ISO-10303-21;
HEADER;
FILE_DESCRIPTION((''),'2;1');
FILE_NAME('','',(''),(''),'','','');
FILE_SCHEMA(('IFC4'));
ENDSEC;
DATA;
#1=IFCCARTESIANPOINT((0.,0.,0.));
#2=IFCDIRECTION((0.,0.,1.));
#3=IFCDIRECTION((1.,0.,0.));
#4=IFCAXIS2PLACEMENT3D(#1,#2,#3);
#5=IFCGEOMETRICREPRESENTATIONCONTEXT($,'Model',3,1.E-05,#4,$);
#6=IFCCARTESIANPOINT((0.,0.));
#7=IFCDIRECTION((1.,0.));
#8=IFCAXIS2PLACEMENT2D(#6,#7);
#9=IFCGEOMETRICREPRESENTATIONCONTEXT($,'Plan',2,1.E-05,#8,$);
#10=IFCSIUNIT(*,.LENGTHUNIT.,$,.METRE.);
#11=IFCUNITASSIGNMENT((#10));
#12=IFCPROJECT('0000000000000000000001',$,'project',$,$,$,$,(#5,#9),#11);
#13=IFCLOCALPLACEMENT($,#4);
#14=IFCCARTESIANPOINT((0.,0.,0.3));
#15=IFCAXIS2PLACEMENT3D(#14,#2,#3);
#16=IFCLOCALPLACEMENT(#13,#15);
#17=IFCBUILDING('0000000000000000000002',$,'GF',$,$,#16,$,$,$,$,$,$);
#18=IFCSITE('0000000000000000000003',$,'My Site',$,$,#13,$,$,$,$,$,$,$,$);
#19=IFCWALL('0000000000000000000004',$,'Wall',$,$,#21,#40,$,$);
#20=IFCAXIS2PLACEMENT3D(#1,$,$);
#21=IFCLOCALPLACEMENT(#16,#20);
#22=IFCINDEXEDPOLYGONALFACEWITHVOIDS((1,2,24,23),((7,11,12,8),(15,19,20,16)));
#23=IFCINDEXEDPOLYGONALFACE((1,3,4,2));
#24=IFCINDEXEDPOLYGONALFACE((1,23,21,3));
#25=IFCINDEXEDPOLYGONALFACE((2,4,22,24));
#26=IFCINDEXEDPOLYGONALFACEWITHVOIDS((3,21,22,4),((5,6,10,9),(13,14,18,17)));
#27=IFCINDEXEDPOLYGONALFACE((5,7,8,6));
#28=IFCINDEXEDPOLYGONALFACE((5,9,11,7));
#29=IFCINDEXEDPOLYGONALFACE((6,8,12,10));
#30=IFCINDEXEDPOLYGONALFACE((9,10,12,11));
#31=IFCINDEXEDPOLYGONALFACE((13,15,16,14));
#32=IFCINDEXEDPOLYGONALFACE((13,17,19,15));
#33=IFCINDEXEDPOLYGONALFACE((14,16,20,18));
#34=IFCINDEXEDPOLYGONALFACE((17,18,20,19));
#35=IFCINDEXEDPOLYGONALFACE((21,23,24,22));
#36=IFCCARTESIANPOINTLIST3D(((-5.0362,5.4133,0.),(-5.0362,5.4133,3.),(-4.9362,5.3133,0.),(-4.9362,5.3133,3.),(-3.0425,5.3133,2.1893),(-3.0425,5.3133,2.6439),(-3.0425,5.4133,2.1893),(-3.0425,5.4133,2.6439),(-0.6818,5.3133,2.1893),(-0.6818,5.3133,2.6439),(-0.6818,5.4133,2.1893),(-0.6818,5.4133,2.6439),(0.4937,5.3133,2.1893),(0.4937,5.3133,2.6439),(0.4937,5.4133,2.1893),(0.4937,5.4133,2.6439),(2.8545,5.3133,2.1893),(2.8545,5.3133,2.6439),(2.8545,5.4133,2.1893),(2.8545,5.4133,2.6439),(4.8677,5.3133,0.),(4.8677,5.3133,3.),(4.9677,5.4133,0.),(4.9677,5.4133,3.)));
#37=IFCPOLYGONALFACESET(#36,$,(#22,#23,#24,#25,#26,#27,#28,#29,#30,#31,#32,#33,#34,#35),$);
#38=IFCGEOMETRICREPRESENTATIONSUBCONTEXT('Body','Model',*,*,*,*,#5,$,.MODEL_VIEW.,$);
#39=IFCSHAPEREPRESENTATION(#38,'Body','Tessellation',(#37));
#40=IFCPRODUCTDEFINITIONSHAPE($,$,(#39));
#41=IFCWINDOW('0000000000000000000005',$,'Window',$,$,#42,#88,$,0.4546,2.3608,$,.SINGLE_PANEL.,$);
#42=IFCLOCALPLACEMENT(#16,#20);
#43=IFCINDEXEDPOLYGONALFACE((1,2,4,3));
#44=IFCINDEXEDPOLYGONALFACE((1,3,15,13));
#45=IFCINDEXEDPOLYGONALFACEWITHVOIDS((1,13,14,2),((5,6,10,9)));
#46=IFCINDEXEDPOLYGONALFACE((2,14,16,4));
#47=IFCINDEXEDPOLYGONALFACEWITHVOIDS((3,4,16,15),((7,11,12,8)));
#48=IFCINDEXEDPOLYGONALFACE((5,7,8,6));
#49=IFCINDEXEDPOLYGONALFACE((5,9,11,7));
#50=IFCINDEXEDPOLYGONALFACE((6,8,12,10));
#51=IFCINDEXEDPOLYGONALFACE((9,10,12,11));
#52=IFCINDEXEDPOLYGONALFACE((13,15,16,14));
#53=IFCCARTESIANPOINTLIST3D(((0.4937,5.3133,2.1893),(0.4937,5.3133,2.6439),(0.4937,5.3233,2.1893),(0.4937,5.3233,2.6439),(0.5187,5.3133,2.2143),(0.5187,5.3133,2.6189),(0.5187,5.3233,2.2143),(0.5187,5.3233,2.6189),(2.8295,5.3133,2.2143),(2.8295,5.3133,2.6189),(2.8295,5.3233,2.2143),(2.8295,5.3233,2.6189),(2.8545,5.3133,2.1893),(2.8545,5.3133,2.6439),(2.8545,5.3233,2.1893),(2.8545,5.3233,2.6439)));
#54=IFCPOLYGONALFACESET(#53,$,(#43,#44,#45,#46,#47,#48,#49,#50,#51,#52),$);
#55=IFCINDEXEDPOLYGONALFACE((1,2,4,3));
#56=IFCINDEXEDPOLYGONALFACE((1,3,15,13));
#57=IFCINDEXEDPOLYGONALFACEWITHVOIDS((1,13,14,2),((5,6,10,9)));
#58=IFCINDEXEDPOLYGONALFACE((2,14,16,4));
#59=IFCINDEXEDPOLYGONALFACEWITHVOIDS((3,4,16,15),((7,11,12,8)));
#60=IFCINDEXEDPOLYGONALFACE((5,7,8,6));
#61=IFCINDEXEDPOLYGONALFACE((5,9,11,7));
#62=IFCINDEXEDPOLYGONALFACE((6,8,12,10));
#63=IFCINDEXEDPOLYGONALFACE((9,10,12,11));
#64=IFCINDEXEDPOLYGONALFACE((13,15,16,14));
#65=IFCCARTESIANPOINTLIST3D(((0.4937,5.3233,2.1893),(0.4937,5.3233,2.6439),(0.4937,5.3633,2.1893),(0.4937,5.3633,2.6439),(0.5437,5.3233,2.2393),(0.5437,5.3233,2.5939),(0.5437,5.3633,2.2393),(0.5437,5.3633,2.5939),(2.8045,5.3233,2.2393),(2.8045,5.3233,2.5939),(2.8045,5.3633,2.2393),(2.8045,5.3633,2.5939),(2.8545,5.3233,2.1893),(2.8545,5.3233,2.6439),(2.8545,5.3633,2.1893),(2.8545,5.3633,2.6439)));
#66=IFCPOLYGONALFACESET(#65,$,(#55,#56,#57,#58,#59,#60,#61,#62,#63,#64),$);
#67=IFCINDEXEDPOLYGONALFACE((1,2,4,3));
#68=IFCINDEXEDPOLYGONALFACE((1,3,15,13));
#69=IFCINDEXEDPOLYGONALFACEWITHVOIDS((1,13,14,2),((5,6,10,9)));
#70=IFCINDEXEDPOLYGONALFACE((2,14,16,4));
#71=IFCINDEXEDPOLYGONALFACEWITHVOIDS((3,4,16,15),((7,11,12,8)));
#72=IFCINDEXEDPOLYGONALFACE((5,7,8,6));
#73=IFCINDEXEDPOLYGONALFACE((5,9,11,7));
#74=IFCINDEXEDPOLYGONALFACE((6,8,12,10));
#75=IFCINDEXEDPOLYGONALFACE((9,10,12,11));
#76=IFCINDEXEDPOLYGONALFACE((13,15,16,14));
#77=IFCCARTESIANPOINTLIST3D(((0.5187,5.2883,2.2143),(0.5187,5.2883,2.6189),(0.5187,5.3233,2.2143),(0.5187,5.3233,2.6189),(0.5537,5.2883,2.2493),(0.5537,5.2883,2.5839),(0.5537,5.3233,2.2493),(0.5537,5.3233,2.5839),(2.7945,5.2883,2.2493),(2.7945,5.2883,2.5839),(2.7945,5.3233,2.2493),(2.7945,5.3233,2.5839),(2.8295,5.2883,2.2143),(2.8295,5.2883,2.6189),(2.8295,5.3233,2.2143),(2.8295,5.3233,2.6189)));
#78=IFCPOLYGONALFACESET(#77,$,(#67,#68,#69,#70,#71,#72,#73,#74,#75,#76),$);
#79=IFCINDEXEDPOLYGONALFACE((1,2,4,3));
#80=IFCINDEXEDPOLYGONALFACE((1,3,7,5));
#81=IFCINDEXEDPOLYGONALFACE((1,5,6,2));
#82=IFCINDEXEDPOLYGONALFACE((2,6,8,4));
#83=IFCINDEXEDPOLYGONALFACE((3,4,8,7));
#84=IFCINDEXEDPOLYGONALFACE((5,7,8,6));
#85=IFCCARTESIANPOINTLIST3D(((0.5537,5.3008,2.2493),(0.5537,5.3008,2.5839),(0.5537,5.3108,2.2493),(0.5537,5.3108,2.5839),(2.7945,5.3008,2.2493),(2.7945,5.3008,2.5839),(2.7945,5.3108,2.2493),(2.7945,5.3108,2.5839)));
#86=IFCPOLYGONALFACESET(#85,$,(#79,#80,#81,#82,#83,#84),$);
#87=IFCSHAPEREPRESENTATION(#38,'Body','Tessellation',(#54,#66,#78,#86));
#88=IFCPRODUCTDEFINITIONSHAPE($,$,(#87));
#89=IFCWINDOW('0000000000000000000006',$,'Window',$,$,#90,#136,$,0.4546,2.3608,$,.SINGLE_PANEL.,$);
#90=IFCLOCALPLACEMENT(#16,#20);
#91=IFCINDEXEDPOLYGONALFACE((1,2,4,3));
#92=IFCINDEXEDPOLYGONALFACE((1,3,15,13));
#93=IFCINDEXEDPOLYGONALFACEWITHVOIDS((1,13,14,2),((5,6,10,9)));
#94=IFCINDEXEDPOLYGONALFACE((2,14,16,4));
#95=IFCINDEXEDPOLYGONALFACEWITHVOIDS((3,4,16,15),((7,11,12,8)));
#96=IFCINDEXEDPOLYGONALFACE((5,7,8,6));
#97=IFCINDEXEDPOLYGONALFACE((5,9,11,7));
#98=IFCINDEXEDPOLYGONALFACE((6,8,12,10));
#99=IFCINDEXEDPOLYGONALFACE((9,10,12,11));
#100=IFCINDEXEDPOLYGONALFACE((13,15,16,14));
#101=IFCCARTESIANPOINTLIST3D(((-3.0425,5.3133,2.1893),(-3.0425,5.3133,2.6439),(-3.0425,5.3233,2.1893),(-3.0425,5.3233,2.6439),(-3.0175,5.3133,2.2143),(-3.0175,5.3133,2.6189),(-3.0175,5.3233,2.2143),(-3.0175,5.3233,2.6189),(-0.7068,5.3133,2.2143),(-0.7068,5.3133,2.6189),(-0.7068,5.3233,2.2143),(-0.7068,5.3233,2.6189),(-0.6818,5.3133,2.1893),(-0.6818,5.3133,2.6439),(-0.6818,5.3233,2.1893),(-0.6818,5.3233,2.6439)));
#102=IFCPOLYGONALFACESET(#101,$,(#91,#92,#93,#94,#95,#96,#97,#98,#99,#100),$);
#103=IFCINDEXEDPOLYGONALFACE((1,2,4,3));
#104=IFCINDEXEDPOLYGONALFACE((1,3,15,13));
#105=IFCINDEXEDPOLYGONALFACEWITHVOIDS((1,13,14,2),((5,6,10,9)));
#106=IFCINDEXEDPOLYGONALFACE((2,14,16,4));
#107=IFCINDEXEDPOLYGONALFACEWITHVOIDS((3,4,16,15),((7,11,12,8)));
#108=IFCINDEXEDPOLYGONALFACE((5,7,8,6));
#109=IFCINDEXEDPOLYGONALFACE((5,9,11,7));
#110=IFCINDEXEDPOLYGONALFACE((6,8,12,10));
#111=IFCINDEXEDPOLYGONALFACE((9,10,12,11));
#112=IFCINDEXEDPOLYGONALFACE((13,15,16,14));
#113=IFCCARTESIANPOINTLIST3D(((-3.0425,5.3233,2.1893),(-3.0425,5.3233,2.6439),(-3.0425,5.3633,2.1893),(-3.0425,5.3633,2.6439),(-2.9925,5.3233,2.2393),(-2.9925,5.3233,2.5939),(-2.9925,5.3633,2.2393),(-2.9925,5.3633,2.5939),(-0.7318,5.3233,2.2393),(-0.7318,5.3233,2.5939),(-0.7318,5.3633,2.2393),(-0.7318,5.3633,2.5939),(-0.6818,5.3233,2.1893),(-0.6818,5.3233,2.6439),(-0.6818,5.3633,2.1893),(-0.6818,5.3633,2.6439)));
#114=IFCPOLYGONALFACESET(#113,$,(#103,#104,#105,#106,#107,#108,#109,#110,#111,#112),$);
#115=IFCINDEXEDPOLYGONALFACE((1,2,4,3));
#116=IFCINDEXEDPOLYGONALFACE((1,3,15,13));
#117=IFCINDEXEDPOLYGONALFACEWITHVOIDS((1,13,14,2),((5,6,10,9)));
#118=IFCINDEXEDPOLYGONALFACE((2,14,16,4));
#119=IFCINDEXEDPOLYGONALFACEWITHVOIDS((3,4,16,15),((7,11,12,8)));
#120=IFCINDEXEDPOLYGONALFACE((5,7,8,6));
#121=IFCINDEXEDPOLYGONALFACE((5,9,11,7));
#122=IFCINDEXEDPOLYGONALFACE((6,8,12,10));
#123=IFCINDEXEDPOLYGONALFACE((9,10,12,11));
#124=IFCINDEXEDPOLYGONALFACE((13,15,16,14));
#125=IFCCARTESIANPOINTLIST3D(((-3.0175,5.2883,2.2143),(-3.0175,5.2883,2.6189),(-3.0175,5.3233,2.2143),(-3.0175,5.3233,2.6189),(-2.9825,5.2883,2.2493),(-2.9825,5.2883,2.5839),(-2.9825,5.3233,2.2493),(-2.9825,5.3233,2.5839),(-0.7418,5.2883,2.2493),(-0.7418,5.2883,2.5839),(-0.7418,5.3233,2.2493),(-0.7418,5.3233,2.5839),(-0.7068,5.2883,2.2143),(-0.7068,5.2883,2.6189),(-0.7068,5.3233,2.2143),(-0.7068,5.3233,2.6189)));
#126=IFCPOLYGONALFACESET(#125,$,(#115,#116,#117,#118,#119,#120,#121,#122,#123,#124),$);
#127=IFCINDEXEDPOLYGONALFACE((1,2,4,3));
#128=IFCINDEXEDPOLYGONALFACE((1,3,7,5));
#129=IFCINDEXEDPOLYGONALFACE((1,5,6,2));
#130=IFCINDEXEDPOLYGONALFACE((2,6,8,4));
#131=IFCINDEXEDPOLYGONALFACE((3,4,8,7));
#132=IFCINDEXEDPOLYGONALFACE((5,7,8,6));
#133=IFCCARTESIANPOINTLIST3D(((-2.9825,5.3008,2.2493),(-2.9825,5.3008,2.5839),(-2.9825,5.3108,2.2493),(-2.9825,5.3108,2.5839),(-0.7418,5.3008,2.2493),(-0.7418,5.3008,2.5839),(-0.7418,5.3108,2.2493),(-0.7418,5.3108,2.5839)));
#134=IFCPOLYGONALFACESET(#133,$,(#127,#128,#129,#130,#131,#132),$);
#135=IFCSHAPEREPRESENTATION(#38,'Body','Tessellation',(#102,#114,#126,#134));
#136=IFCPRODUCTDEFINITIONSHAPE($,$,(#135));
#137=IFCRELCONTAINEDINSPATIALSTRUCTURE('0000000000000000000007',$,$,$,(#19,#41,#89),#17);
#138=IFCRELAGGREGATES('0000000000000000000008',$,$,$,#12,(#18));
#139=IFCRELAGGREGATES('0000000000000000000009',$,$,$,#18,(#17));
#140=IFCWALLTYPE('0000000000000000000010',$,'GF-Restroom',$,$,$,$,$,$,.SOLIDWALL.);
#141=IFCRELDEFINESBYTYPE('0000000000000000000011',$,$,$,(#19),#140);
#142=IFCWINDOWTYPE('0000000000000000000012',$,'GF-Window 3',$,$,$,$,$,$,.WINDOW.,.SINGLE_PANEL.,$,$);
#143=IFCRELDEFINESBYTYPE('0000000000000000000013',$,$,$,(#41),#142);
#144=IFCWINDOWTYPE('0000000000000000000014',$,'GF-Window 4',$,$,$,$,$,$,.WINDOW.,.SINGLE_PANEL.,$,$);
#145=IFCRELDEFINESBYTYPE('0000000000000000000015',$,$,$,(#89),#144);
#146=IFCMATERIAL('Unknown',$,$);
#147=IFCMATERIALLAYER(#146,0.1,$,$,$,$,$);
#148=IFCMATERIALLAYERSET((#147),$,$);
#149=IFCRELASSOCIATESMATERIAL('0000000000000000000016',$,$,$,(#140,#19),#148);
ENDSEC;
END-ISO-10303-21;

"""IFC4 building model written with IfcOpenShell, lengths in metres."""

from ifc_helpers import new_model, entity, si_unit, frame, origin_with_axes, origin_2d_with_axis, place, context, subcontext, project, spatial, line, indexed_curve, outline, extrude, shape, source, transform, mapped, material, layer, layer_set, layer_usage, type_object, type_shapes, element, fill, save


model = new_model("IFC4")

# Units and contexts
model_context = context("Model", 3, precision=1e-05, world=origin_with_axes())
plan_context = context("Plan", 2, precision=1e-05, world=origin_2d_with_axis())
body_context_1 = subcontext(model_context, "Body", "Model", "MODEL_VIEW")
body_context_2 = subcontext(plan_context, "Body", "Plan", "PLAN_VIEW")
ifc_project = project(units=[si_unit("LENGTHUNIT", "METRE")], contexts=[model_context, plan_context])

# Site, building
site_placement = place(None, origin_with_axes())
site = spatial("IfcSite", under=ifc_project, at=site_placement, Name="My Site")
building_placement = place(site_placement, frame((0.0, 0.0, 0.3), z_axis=(0.0, 0.0, 1.0), x_axis=(1.0, 0.0, 0.0)))
building = spatial("IfcBuilding", under=site, at=building_placement, Name="GF")

# Shared definitions
ifc_material = material(Name="Unknown")

# Shared definitions
ifc_layer_1 = layer(ifc_material, 0.1)
ifc_layer_set_1 = layer_set([ifc_layer_1])
wall_type_1 = type_object("IfcWallType", Name="GF-Restroom", PredefinedType="SOLIDWALL", material=ifc_layer_set_1)

# Wall, openings, windows
ifc_layer_usage_1 = layer_usage(ifc_layer_set_1, "AXIS2", "POSITIVE", 0.0)
wall_1_placement = place(building_placement, frame((4.9677, 5.4133, 0.0), z_axis=(0.0, 0.0, 1.0), x_axis=(-1.0, 0.0, 0.0)))
wall_1 = element("IfcWall", 1, at=wall_1_placement, inside=building, type_object=wall_type_1, material=ifc_layer_usage_1, Name="Wall", context=body_context_1, shape_type="SweptSolid", body=[
    extrude(outline(indexed_curve([(0.0, 0.0), (0.1, 0.1), (9.904, 0.1), (10.004, 0.0)], segments=[line(1, 2, 3, 4, 1)])), origin_with_axes(), (0.0, 0.0, 1.0), 3.0),
])
shared_shape_1 = source(origin_with_axes(), body_context_1, "Body", "SweptSolid", [
    extrude(outline(indexed_curve([(0.0, 0.0), (2.3608, 0.0), (2.3608, 0.4546), (0.0, 0.4546)], segments=[line(1, 2, 3, 4, 1)])), frame((0.0, -0.6, 0.0), z_axis=(0.0, -1.0, 0.0), x_axis=(1.0, 0.0, 0.0)), (0.0, 0.0, -1.0), 1.2),
])
opening_1_placement = place(wall_1_placement, frame((2.1133, 0.0, 2.1893), z_axis=(0.0, 0.0, 1.0), x_axis=(1.0, 0.0, 0.0)))
opening_1 = element("IfcOpeningElement", 2, at=opening_1_placement, cuts=wall_1, PredefinedType="OPENING", context=body_context_1, shape_type="MappedRepresentation", body=[
    mapped(shared_shape_1, transform((0.0, 0.0, 0.0), x_axis=(1.0, 0.0, 0.0), y_axis=(0.0, 1.0, 0.0), z_axis=(0.0, 0.0, 1.0), scale=1.0)),
])
shared_shape_2 = source(origin_with_axes(), body_context_1, "Body", "SweptSolid", [
    extrude(outline(indexed_curve([(0.0, 0.0), (2.3608, 0.0), (2.3608, 0.4546), (0.0, 0.4546)], segments=[line(1, 2, 3, 4, 1)])), frame((0.0, -0.6, 0.0), z_axis=(0.0, -1.0, 0.0), x_axis=(1.0, 0.0, 0.0)), (0.0, 0.0, -1.0), 1.2),
])
opening_2_placement = place(wall_1_placement, frame((5.6495, 0.0, 2.1893), z_axis=(0.0, 0.0, 1.0), x_axis=(1.0, 0.0, 0.0)))
opening_2 = element("IfcOpeningElement", 3, at=opening_2_placement, cuts=wall_1, PredefinedType="OPENING", context=body_context_1, shape_type="MappedRepresentation", body=[
    mapped(shared_shape_2, transform((0.0, 0.0, 0.0), x_axis=(1.0, 0.0, 0.0), y_axis=(0.0, 1.0, 0.0), z_axis=(0.0, 0.0, 1.0), scale=1.0)),
])
window_type_1 = type_object("IfcWindowType", Name="GF-Window 3", PartitioningType="SINGLE_PANEL", PredefinedType="WINDOW")
shared_shape_3 = source(origin_with_axes(), body_context_1, "Body", "SweptSolid", [
    extrude(outline(indexed_curve([(0.0, 0.0), (2.3608, 0.0), (2.3608, 0.4546), (0.0, 0.4546)], segments=[line(1, 2, 3, 4, 1)]), holes=[indexed_curve([(0.025, 0.025), (2.3358, 0.025), (2.3358, 0.4296), (0.025, 0.4296)], segments=[line(1, 2, 3, 4, 1)])]), frame((0.0, 0.09, 0.0), z_axis=(0.0, -1.0, 0.0), x_axis=(1.0, 0.0, 0.0)), (0.0, 0.0, -1.0), 0.01),
    extrude(outline(indexed_curve([(0.0, 0.0), (2.3608, 0.0), (2.3608, 0.4546), (0.0, 0.4546)], segments=[line(1, 2, 3, 4, 1)]), holes=[indexed_curve([(0.05, 0.05), (2.3108, 0.05), (2.3108, 0.4046), (0.05, 0.4046)], segments=[line(1, 2, 3, 4, 1)])]), frame((0.0, 0.05, 0.0), z_axis=(0.0, -1.0, 0.0), x_axis=(1.0, 0.0, 0.0)), (0.0, 0.0, -1.0), 0.04),
    extrude(outline(indexed_curve([(0.0, 0.0), (2.3108, 0.0), (2.3108, 0.4046), (0.0, 0.4046)], segments=[line(1, 2, 3, 4, 1)]), holes=[indexed_curve([(0.035, 0.035), (2.2758, 0.035), (2.2758, 0.3696), (0.035, 0.3696)], segments=[line(1, 2, 3, 4, 1)])]), frame((0.025, 0.09, 0.025), z_axis=(0.0, -1.0, 0.0), x_axis=(1.0, 0.0, 0.0)), (0.0, 0.0, -1.0), 0.035),
    extrude(outline(indexed_curve([(0.035, 0.035), (2.2758, 0.035), (2.2758, 0.3696), (0.035, 0.3696)], segments=[line(1, 2, 3, 4, 1)])), frame((0.025, 0.1025, 0.025), z_axis=(0.0, -1.0, 0.0), x_axis=(1.0, 0.0, 0.0)), (0.0, 0.0, -1.0), 0.01),
])
shared_shape_4 = source(origin_with_axes(), body_context_2, "Body", "Curve2D", [
    entity("IfcIndexedPolyCurve", entity("IfcCartesianPointList2D", [[0.05, 0.05], [2.3108, 0.05]])),
    entity("IfcIndexedPolyCurve", entity("IfcCartesianPointList2D", [[0.0, 0.1], [0.025, 0.1], [0.025, 0.09], [0.05, 0.09], [0.05, 0.05], [0.0, 0.05]]), [entity("IfcLineIndex", [1, 2, 3, 4, 5, 6, 1])]),
    entity("IfcIndexedPolyCurve", entity("IfcCartesianPointList2D", [[2.3608, 0.1], [2.3358, 0.1], [2.3358, 0.09], [2.3108, 0.09], [2.3108, 0.05], [2.3608, 0.05]]), [entity("IfcLineIndex", [1, 2, 3, 4, 5, 6, 1])]),
    entity("IfcIndexedPolyCurve", entity("IfcCartesianPointList2D", [[0.025, 0.09], [0.06, 0.09], [0.06, 0.125], [0.025, 0.125]]), [entity("IfcLineIndex", [1, 2, 3, 4, 1])]),
    entity("IfcIndexedPolyCurve", entity("IfcCartesianPointList2D", [[2.3358, 0.09], [2.3008, 0.09], [2.3008, 0.125], [2.3358, 0.125]]), [entity("IfcLineIndex", [1, 2, 3, 4, 1])]),
    entity("IfcIndexedPolyCurve", entity("IfcCartesianPointList2D", [[0.06, 0.09], [2.3008, 0.09]])),
    entity("IfcIndexedPolyCurve", entity("IfcCartesianPointList2D", [[0.06, 0.125], [2.3008, 0.125]])),
    entity("IfcIndexedPolyCurve", entity("IfcCartesianPointList2D", [[0.06, 0.1075], [2.3008, 0.1075]])),
])
type_shapes(window_type_1, [shared_shape_3, shared_shape_4])
window_1_placement = place(opening_1_placement, frame((0.0, 0.0, 0.0), z_axis=(0.0, 0.0, 1.0), x_axis=(1.0, 0.0, 0.0)))
window_1 = element("IfcWindow", 4, at=window_1_placement, inside=building, type_object=window_type_1, Name="Window", OverallHeight=0.4546, OverallWidth=2.3608, PartitioningType="SINGLE_PANEL", shapes=[
    shape(body_context_1, "Body", "MappedRepresentation", [mapped(shared_shape_3, transform((0.0, 0.0, 0.0), x_axis=(1.0, 0.0, 0.0), y_axis=(0.0, 1.0, 0.0), z_axis=(0.0, 0.0, 1.0), scale=1.0))]),
    shape(body_context_2, "Body", "MappedRepresentation", [mapped(shared_shape_4, transform((0.0, 0.0, 0.0), x_axis=(1.0, 0.0, 0.0), y_axis=(0.0, 1.0, 0.0), z_axis=(0.0, 0.0, 1.0), scale=1.0))]),
])
fill(opening_1, window_1)
window_type_2 = type_object("IfcWindowType", Name="GF-Window 4", PartitioningType="SINGLE_PANEL", PredefinedType="WINDOW")
shared_shape_5 = source(origin_with_axes(), body_context_1, "Body", "SweptSolid", [
    extrude(outline(indexed_curve([(0.0, 0.0), (2.3608, 0.0), (2.3608, 0.4546), (0.0, 0.4546)], segments=[line(1, 2, 3, 4, 1)]), holes=[indexed_curve([(0.025, 0.025), (2.3358, 0.025), (2.3358, 0.4296), (0.025, 0.4296)], segments=[line(1, 2, 3, 4, 1)])]), frame((0.0, 0.09, 0.0), z_axis=(0.0, -1.0, 0.0), x_axis=(1.0, 0.0, 0.0)), (0.0, 0.0, -1.0), 0.01),
    extrude(outline(indexed_curve([(0.0, 0.0), (2.3608, 0.0), (2.3608, 0.4546), (0.0, 0.4546)], segments=[line(1, 2, 3, 4, 1)]), holes=[indexed_curve([(0.05, 0.05), (2.3108, 0.05), (2.3108, 0.4046), (0.05, 0.4046)], segments=[line(1, 2, 3, 4, 1)])]), frame((0.0, 0.05, 0.0), z_axis=(0.0, -1.0, 0.0), x_axis=(1.0, 0.0, 0.0)), (0.0, 0.0, -1.0), 0.04),
    extrude(outline(indexed_curve([(0.0, 0.0), (2.3108, 0.0), (2.3108, 0.4046), (0.0, 0.4046)], segments=[line(1, 2, 3, 4, 1)]), holes=[indexed_curve([(0.035, 0.035), (2.2758, 0.035), (2.2758, 0.3696), (0.035, 0.3696)], segments=[line(1, 2, 3, 4, 1)])]), frame((0.025, 0.09, 0.025), z_axis=(0.0, -1.0, 0.0), x_axis=(1.0, 0.0, 0.0)), (0.0, 0.0, -1.0), 0.035),
    extrude(outline(indexed_curve([(0.035, 0.035), (2.2758, 0.035), (2.2758, 0.3696), (0.035, 0.3696)], segments=[line(1, 2, 3, 4, 1)])), frame((0.025, 0.1025, 0.025), z_axis=(0.0, -1.0, 0.0), x_axis=(1.0, 0.0, 0.0)), (0.0, 0.0, -1.0), 0.01),
])
shared_shape_6 = source(origin_with_axes(), body_context_2, "Body", "Curve2D", [
    entity("IfcIndexedPolyCurve", entity("IfcCartesianPointList2D", [[0.05, 0.05], [2.3108, 0.05]])),
    entity("IfcIndexedPolyCurve", entity("IfcCartesianPointList2D", [[0.0, 0.1], [0.025, 0.1], [0.025, 0.09], [0.05, 0.09], [0.05, 0.05], [0.0, 0.05]]), [entity("IfcLineIndex", [1, 2, 3, 4, 5, 6, 1])]),
    entity("IfcIndexedPolyCurve", entity("IfcCartesianPointList2D", [[2.3608, 0.1], [2.3358, 0.1], [2.3358, 0.09], [2.3108, 0.09], [2.3108, 0.05], [2.3608, 0.05]]), [entity("IfcLineIndex", [1, 2, 3, 4, 5, 6, 1])]),
    entity("IfcIndexedPolyCurve", entity("IfcCartesianPointList2D", [[0.025, 0.09], [0.06, 0.09], [0.06, 0.125], [0.025, 0.125]]), [entity("IfcLineIndex", [1, 2, 3, 4, 1])]),
    entity("IfcIndexedPolyCurve", entity("IfcCartesianPointList2D", [[2.3358, 0.09], [2.3008, 0.09], [2.3008, 0.125], [2.3358, 0.125]]), [entity("IfcLineIndex", [1, 2, 3, 4, 1])]),
    entity("IfcIndexedPolyCurve", entity("IfcCartesianPointList2D", [[0.06, 0.09], [2.3008, 0.09]])),
    entity("IfcIndexedPolyCurve", entity("IfcCartesianPointList2D", [[0.06, 0.125], [2.3008, 0.125]])),
    entity("IfcIndexedPolyCurve", entity("IfcCartesianPointList2D", [[0.06, 0.1075], [2.3008, 0.1075]])),
])
type_shapes(window_type_2, [shared_shape_5, shared_shape_6])
window_2_placement = place(opening_2_placement, frame((0.0, 0.0, 0.0), z_axis=(0.0, 0.0, 1.0), x_axis=(1.0, 0.0, 0.0)))
window_2 = element("IfcWindow", 5, at=window_2_placement, inside=building, type_object=window_type_2, Name="Window", OverallHeight=0.4546, OverallWidth=2.3608, PartitioningType="SINGLE_PANEL", shapes=[
    shape(body_context_1, "Body", "MappedRepresentation", [mapped(shared_shape_5, transform((0.0, 0.0, 0.0), x_axis=(1.0, 0.0, 0.0), y_axis=(0.0, 1.0, 0.0), z_axis=(0.0, 0.0, 1.0), scale=1.0))]),
    shape(body_context_2, "Body", "MappedRepresentation", [mapped(shared_shape_6, transform((0.0, 0.0, 0.0), x_axis=(1.0, 0.0, 0.0), y_axis=(0.0, 1.0, 0.0), z_axis=(0.0, 0.0, 1.0), scale=1.0))]),
])
fill(opening_2, window_2)

save(model, "model.ifc")
